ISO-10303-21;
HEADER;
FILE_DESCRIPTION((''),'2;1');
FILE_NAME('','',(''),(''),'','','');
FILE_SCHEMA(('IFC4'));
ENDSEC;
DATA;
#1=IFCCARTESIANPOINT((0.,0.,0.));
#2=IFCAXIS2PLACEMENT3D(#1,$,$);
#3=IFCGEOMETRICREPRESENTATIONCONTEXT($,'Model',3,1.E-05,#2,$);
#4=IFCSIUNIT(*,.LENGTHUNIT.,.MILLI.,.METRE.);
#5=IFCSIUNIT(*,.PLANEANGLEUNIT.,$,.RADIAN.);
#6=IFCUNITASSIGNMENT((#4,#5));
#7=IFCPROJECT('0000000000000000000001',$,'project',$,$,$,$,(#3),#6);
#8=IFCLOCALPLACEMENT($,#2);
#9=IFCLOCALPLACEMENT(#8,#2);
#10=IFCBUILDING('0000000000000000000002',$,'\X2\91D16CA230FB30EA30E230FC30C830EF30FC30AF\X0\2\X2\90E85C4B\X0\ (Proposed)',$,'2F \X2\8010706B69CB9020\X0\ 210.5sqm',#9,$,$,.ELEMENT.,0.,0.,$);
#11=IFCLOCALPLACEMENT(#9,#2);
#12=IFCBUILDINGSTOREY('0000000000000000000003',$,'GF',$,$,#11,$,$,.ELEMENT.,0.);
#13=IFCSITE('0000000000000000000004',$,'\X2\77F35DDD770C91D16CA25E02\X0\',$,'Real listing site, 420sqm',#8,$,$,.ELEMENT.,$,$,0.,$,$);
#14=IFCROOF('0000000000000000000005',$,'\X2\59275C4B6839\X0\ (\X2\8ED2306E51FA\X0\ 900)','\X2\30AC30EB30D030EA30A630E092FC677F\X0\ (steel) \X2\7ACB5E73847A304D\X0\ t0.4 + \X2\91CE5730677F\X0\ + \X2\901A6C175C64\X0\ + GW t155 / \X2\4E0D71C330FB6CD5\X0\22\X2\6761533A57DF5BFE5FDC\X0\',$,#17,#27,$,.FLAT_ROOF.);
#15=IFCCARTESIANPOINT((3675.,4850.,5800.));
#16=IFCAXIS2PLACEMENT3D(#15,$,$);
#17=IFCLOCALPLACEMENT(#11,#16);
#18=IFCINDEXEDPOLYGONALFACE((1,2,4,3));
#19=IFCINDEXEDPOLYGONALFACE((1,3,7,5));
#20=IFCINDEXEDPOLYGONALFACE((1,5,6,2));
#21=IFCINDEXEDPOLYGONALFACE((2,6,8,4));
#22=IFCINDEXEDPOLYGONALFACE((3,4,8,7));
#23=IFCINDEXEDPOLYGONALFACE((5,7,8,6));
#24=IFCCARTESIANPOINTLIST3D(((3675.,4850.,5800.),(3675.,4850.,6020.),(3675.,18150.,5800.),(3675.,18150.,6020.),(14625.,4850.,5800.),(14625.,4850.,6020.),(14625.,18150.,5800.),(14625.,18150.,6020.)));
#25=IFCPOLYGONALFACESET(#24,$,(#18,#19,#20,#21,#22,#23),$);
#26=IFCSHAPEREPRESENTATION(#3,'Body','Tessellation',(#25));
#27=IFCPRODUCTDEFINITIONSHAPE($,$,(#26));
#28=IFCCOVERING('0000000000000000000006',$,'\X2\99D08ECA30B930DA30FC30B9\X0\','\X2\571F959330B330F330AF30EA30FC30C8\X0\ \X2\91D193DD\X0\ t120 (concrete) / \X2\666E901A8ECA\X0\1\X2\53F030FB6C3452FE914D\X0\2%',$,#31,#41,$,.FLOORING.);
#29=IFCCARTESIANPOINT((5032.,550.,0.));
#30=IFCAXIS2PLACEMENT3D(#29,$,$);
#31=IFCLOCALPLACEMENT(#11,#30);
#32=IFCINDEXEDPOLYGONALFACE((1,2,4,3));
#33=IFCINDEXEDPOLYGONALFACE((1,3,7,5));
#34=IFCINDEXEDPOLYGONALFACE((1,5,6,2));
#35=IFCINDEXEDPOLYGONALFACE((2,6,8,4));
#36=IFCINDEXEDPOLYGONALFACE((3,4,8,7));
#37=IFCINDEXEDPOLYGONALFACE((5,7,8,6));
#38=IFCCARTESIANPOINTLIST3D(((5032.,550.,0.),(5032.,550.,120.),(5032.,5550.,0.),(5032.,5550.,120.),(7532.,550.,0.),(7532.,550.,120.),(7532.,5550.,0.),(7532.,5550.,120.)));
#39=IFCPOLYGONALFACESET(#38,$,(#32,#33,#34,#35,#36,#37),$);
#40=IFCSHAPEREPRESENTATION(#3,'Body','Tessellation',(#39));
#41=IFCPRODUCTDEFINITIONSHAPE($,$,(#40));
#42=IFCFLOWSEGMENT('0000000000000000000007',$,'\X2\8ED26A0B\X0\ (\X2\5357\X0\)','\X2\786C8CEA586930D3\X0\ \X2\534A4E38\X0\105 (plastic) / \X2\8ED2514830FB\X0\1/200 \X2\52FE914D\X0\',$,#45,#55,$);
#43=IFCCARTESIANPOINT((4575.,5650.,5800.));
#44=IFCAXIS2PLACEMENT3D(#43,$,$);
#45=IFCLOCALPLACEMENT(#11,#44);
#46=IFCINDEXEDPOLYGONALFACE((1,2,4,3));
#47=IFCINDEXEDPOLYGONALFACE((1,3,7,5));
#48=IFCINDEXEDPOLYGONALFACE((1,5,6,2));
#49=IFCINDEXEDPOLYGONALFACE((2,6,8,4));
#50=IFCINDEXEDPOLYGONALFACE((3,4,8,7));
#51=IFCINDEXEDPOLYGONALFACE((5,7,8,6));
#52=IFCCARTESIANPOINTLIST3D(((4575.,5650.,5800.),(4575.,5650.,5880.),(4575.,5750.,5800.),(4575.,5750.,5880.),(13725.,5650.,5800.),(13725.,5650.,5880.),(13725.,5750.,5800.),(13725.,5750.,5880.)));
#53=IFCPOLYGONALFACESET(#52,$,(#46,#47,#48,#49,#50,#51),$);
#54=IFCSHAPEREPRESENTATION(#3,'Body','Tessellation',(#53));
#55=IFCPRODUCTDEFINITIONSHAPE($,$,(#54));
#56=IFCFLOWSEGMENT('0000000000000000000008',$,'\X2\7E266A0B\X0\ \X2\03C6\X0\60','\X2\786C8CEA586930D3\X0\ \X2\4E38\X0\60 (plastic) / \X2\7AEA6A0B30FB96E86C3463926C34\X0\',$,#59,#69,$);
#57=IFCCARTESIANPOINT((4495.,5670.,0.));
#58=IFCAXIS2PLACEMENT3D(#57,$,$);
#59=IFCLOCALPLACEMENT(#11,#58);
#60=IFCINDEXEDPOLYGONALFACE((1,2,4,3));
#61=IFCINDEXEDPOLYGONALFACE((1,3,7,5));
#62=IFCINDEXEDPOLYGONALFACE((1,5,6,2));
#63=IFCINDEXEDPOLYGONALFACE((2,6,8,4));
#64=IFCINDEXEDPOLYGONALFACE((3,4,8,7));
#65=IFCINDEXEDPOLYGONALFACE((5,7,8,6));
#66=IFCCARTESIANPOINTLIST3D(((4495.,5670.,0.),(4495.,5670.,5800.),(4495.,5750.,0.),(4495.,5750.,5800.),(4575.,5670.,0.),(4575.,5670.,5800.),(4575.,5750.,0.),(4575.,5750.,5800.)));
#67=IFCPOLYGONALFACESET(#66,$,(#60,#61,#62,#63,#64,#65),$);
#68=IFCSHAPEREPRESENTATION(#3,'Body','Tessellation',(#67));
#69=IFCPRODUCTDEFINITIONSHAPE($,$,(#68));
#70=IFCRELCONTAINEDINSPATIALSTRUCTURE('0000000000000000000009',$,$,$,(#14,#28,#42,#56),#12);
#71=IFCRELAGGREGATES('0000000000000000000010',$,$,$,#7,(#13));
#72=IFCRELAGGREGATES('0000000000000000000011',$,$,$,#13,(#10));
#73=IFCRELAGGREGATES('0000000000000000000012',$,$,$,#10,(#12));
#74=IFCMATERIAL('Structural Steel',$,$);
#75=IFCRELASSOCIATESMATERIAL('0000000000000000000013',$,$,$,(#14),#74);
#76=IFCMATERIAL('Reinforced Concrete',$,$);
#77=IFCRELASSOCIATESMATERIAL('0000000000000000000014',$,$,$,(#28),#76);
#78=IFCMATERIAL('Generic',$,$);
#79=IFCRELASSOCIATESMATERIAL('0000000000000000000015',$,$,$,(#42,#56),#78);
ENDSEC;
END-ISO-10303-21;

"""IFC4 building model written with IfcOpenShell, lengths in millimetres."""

from ifc_helpers import new_model, si_unit, frame, frame_2d, origin, place, context, project, spatial, rectangle, extrude, material, element, save


model = new_model("IFC4")

# Units and contexts
model_context = context("Model", 3, precision=1e-05, world=origin())
ifc_project = project(units=[si_unit("LENGTHUNIT", "METRE", prefix="MILLI"), si_unit("PLANEANGLEUNIT", "RADIAN")], contexts=[model_context])

# Site, building, storey
site_placement = place(None, origin())
site = spatial("IfcSite", under=ifc_project, at=site_placement, Name="石川県金沢市", ObjectType="Real listing site, 420sqm", CompositionType="ELEMENT", RefElevation=0.0)
building_placement = place(site_placement, origin())
building = spatial("IfcBuilding", under=site, at=building_placement, Name="金沢・リモートワーク2部屋 (Proposed)", ObjectType="2F 耐火構造 210.5sqm", CompositionType="ELEMENT", ElevationOfRefHeight=0.0, ElevationOfTerrain=0.0)
storey_placement = place(building_placement, origin())
storey = spatial("IfcBuildingStorey", under=building, at=storey_placement, Name="GF", CompositionType="ELEMENT", Elevation=0.0)

# Shared definitions
ifc_material_1 = material(Name="Reinforced Concrete")

# Roof
ifc_material_2 = material(Name="Structural Steel")
roof_placement = place(storey_placement, frame((3675.0, 4850.0, 5800.0)))
element("IfcRoof", 1, at=roof_placement, inside=storey, material=ifc_material_2, Name="大屋根 (軒の出 900)", Description="ガルバリウム鋼板 (steel) 立平葺き t0.4 + 野地板 + 通気層 + GW t155 / 不燃・法22条区域対応", PredefinedType="FLAT_ROOF", context=model_context, shape_type="SweptSolid", body=[
    extrude(rectangle(XDim=10950.0, YDim=13300.0, at=frame_2d((5475.0, 6650.0))), frame((3675.0, 4850.0, 5800.0)), (0.0, 0.0, 1.0), 220.0),
])

# Covering
covering_placement = place(storey_placement, frame((5032.0, 550.0, 0.0)))
element("IfcCovering", 2, at=covering_placement, inside=storey, material=ifc_material_1, Name="駐車スペース", Description="土間コンクリート 金鏝 t120 (concrete) / 普通車1台・水勾配2%", PredefinedType="FLOORING", context=model_context, shape_type="SweptSolid", body=[
    extrude(rectangle(XDim=2500.0, YDim=5000.0, at=frame_2d((1250.0, 2500.0))), frame((5032.0, 550.0, 0.0)), (0.0, 0.0, 1.0), 120.0),
])

# Flow segments
ifc_material_3 = material(Name="Generic")
flow_segment_1_placement = place(storey_placement, frame((4575.0, 5650.0, 5800.0)))
element("IfcFlowSegment", 3, at=flow_segment_1_placement, inside=storey, material=ifc_material_3, Name="軒樋 (南)", Description="硬質塩ビ 半丸105 (plastic) / 軒先・1/200 勾配", context=model_context, shape_type="SweptSolid", body=[
    extrude(rectangle(XDim=9150.0, YDim=100.0, at=frame_2d((4575.0, 50.0))), frame((4575.0, 5650.0, 5800.0)), (0.0, 0.0, 1.0), 80.0),
])
flow_segment_2_placement = place(storey_placement, frame((4495.0, 5670.0, 0.0)))
element("IfcFlowSegment", 4, at=flow_segment_2_placement, inside=storey, material=ifc_material_3, Name="縦樋 φ60", Description="硬質塩ビ 丸60 (plastic) / 竪樋・雨水排水", context=model_context, shape_type="SweptSolid", body=[
    extrude(rectangle(XDim=80.0, YDim=80.0, at=frame_2d((40.0, 40.0))), frame((4495.0, 5670.0, 0.0)), (0.0, 0.0, 1.0), 5800.0),
])

save(model, "model.ifc")
